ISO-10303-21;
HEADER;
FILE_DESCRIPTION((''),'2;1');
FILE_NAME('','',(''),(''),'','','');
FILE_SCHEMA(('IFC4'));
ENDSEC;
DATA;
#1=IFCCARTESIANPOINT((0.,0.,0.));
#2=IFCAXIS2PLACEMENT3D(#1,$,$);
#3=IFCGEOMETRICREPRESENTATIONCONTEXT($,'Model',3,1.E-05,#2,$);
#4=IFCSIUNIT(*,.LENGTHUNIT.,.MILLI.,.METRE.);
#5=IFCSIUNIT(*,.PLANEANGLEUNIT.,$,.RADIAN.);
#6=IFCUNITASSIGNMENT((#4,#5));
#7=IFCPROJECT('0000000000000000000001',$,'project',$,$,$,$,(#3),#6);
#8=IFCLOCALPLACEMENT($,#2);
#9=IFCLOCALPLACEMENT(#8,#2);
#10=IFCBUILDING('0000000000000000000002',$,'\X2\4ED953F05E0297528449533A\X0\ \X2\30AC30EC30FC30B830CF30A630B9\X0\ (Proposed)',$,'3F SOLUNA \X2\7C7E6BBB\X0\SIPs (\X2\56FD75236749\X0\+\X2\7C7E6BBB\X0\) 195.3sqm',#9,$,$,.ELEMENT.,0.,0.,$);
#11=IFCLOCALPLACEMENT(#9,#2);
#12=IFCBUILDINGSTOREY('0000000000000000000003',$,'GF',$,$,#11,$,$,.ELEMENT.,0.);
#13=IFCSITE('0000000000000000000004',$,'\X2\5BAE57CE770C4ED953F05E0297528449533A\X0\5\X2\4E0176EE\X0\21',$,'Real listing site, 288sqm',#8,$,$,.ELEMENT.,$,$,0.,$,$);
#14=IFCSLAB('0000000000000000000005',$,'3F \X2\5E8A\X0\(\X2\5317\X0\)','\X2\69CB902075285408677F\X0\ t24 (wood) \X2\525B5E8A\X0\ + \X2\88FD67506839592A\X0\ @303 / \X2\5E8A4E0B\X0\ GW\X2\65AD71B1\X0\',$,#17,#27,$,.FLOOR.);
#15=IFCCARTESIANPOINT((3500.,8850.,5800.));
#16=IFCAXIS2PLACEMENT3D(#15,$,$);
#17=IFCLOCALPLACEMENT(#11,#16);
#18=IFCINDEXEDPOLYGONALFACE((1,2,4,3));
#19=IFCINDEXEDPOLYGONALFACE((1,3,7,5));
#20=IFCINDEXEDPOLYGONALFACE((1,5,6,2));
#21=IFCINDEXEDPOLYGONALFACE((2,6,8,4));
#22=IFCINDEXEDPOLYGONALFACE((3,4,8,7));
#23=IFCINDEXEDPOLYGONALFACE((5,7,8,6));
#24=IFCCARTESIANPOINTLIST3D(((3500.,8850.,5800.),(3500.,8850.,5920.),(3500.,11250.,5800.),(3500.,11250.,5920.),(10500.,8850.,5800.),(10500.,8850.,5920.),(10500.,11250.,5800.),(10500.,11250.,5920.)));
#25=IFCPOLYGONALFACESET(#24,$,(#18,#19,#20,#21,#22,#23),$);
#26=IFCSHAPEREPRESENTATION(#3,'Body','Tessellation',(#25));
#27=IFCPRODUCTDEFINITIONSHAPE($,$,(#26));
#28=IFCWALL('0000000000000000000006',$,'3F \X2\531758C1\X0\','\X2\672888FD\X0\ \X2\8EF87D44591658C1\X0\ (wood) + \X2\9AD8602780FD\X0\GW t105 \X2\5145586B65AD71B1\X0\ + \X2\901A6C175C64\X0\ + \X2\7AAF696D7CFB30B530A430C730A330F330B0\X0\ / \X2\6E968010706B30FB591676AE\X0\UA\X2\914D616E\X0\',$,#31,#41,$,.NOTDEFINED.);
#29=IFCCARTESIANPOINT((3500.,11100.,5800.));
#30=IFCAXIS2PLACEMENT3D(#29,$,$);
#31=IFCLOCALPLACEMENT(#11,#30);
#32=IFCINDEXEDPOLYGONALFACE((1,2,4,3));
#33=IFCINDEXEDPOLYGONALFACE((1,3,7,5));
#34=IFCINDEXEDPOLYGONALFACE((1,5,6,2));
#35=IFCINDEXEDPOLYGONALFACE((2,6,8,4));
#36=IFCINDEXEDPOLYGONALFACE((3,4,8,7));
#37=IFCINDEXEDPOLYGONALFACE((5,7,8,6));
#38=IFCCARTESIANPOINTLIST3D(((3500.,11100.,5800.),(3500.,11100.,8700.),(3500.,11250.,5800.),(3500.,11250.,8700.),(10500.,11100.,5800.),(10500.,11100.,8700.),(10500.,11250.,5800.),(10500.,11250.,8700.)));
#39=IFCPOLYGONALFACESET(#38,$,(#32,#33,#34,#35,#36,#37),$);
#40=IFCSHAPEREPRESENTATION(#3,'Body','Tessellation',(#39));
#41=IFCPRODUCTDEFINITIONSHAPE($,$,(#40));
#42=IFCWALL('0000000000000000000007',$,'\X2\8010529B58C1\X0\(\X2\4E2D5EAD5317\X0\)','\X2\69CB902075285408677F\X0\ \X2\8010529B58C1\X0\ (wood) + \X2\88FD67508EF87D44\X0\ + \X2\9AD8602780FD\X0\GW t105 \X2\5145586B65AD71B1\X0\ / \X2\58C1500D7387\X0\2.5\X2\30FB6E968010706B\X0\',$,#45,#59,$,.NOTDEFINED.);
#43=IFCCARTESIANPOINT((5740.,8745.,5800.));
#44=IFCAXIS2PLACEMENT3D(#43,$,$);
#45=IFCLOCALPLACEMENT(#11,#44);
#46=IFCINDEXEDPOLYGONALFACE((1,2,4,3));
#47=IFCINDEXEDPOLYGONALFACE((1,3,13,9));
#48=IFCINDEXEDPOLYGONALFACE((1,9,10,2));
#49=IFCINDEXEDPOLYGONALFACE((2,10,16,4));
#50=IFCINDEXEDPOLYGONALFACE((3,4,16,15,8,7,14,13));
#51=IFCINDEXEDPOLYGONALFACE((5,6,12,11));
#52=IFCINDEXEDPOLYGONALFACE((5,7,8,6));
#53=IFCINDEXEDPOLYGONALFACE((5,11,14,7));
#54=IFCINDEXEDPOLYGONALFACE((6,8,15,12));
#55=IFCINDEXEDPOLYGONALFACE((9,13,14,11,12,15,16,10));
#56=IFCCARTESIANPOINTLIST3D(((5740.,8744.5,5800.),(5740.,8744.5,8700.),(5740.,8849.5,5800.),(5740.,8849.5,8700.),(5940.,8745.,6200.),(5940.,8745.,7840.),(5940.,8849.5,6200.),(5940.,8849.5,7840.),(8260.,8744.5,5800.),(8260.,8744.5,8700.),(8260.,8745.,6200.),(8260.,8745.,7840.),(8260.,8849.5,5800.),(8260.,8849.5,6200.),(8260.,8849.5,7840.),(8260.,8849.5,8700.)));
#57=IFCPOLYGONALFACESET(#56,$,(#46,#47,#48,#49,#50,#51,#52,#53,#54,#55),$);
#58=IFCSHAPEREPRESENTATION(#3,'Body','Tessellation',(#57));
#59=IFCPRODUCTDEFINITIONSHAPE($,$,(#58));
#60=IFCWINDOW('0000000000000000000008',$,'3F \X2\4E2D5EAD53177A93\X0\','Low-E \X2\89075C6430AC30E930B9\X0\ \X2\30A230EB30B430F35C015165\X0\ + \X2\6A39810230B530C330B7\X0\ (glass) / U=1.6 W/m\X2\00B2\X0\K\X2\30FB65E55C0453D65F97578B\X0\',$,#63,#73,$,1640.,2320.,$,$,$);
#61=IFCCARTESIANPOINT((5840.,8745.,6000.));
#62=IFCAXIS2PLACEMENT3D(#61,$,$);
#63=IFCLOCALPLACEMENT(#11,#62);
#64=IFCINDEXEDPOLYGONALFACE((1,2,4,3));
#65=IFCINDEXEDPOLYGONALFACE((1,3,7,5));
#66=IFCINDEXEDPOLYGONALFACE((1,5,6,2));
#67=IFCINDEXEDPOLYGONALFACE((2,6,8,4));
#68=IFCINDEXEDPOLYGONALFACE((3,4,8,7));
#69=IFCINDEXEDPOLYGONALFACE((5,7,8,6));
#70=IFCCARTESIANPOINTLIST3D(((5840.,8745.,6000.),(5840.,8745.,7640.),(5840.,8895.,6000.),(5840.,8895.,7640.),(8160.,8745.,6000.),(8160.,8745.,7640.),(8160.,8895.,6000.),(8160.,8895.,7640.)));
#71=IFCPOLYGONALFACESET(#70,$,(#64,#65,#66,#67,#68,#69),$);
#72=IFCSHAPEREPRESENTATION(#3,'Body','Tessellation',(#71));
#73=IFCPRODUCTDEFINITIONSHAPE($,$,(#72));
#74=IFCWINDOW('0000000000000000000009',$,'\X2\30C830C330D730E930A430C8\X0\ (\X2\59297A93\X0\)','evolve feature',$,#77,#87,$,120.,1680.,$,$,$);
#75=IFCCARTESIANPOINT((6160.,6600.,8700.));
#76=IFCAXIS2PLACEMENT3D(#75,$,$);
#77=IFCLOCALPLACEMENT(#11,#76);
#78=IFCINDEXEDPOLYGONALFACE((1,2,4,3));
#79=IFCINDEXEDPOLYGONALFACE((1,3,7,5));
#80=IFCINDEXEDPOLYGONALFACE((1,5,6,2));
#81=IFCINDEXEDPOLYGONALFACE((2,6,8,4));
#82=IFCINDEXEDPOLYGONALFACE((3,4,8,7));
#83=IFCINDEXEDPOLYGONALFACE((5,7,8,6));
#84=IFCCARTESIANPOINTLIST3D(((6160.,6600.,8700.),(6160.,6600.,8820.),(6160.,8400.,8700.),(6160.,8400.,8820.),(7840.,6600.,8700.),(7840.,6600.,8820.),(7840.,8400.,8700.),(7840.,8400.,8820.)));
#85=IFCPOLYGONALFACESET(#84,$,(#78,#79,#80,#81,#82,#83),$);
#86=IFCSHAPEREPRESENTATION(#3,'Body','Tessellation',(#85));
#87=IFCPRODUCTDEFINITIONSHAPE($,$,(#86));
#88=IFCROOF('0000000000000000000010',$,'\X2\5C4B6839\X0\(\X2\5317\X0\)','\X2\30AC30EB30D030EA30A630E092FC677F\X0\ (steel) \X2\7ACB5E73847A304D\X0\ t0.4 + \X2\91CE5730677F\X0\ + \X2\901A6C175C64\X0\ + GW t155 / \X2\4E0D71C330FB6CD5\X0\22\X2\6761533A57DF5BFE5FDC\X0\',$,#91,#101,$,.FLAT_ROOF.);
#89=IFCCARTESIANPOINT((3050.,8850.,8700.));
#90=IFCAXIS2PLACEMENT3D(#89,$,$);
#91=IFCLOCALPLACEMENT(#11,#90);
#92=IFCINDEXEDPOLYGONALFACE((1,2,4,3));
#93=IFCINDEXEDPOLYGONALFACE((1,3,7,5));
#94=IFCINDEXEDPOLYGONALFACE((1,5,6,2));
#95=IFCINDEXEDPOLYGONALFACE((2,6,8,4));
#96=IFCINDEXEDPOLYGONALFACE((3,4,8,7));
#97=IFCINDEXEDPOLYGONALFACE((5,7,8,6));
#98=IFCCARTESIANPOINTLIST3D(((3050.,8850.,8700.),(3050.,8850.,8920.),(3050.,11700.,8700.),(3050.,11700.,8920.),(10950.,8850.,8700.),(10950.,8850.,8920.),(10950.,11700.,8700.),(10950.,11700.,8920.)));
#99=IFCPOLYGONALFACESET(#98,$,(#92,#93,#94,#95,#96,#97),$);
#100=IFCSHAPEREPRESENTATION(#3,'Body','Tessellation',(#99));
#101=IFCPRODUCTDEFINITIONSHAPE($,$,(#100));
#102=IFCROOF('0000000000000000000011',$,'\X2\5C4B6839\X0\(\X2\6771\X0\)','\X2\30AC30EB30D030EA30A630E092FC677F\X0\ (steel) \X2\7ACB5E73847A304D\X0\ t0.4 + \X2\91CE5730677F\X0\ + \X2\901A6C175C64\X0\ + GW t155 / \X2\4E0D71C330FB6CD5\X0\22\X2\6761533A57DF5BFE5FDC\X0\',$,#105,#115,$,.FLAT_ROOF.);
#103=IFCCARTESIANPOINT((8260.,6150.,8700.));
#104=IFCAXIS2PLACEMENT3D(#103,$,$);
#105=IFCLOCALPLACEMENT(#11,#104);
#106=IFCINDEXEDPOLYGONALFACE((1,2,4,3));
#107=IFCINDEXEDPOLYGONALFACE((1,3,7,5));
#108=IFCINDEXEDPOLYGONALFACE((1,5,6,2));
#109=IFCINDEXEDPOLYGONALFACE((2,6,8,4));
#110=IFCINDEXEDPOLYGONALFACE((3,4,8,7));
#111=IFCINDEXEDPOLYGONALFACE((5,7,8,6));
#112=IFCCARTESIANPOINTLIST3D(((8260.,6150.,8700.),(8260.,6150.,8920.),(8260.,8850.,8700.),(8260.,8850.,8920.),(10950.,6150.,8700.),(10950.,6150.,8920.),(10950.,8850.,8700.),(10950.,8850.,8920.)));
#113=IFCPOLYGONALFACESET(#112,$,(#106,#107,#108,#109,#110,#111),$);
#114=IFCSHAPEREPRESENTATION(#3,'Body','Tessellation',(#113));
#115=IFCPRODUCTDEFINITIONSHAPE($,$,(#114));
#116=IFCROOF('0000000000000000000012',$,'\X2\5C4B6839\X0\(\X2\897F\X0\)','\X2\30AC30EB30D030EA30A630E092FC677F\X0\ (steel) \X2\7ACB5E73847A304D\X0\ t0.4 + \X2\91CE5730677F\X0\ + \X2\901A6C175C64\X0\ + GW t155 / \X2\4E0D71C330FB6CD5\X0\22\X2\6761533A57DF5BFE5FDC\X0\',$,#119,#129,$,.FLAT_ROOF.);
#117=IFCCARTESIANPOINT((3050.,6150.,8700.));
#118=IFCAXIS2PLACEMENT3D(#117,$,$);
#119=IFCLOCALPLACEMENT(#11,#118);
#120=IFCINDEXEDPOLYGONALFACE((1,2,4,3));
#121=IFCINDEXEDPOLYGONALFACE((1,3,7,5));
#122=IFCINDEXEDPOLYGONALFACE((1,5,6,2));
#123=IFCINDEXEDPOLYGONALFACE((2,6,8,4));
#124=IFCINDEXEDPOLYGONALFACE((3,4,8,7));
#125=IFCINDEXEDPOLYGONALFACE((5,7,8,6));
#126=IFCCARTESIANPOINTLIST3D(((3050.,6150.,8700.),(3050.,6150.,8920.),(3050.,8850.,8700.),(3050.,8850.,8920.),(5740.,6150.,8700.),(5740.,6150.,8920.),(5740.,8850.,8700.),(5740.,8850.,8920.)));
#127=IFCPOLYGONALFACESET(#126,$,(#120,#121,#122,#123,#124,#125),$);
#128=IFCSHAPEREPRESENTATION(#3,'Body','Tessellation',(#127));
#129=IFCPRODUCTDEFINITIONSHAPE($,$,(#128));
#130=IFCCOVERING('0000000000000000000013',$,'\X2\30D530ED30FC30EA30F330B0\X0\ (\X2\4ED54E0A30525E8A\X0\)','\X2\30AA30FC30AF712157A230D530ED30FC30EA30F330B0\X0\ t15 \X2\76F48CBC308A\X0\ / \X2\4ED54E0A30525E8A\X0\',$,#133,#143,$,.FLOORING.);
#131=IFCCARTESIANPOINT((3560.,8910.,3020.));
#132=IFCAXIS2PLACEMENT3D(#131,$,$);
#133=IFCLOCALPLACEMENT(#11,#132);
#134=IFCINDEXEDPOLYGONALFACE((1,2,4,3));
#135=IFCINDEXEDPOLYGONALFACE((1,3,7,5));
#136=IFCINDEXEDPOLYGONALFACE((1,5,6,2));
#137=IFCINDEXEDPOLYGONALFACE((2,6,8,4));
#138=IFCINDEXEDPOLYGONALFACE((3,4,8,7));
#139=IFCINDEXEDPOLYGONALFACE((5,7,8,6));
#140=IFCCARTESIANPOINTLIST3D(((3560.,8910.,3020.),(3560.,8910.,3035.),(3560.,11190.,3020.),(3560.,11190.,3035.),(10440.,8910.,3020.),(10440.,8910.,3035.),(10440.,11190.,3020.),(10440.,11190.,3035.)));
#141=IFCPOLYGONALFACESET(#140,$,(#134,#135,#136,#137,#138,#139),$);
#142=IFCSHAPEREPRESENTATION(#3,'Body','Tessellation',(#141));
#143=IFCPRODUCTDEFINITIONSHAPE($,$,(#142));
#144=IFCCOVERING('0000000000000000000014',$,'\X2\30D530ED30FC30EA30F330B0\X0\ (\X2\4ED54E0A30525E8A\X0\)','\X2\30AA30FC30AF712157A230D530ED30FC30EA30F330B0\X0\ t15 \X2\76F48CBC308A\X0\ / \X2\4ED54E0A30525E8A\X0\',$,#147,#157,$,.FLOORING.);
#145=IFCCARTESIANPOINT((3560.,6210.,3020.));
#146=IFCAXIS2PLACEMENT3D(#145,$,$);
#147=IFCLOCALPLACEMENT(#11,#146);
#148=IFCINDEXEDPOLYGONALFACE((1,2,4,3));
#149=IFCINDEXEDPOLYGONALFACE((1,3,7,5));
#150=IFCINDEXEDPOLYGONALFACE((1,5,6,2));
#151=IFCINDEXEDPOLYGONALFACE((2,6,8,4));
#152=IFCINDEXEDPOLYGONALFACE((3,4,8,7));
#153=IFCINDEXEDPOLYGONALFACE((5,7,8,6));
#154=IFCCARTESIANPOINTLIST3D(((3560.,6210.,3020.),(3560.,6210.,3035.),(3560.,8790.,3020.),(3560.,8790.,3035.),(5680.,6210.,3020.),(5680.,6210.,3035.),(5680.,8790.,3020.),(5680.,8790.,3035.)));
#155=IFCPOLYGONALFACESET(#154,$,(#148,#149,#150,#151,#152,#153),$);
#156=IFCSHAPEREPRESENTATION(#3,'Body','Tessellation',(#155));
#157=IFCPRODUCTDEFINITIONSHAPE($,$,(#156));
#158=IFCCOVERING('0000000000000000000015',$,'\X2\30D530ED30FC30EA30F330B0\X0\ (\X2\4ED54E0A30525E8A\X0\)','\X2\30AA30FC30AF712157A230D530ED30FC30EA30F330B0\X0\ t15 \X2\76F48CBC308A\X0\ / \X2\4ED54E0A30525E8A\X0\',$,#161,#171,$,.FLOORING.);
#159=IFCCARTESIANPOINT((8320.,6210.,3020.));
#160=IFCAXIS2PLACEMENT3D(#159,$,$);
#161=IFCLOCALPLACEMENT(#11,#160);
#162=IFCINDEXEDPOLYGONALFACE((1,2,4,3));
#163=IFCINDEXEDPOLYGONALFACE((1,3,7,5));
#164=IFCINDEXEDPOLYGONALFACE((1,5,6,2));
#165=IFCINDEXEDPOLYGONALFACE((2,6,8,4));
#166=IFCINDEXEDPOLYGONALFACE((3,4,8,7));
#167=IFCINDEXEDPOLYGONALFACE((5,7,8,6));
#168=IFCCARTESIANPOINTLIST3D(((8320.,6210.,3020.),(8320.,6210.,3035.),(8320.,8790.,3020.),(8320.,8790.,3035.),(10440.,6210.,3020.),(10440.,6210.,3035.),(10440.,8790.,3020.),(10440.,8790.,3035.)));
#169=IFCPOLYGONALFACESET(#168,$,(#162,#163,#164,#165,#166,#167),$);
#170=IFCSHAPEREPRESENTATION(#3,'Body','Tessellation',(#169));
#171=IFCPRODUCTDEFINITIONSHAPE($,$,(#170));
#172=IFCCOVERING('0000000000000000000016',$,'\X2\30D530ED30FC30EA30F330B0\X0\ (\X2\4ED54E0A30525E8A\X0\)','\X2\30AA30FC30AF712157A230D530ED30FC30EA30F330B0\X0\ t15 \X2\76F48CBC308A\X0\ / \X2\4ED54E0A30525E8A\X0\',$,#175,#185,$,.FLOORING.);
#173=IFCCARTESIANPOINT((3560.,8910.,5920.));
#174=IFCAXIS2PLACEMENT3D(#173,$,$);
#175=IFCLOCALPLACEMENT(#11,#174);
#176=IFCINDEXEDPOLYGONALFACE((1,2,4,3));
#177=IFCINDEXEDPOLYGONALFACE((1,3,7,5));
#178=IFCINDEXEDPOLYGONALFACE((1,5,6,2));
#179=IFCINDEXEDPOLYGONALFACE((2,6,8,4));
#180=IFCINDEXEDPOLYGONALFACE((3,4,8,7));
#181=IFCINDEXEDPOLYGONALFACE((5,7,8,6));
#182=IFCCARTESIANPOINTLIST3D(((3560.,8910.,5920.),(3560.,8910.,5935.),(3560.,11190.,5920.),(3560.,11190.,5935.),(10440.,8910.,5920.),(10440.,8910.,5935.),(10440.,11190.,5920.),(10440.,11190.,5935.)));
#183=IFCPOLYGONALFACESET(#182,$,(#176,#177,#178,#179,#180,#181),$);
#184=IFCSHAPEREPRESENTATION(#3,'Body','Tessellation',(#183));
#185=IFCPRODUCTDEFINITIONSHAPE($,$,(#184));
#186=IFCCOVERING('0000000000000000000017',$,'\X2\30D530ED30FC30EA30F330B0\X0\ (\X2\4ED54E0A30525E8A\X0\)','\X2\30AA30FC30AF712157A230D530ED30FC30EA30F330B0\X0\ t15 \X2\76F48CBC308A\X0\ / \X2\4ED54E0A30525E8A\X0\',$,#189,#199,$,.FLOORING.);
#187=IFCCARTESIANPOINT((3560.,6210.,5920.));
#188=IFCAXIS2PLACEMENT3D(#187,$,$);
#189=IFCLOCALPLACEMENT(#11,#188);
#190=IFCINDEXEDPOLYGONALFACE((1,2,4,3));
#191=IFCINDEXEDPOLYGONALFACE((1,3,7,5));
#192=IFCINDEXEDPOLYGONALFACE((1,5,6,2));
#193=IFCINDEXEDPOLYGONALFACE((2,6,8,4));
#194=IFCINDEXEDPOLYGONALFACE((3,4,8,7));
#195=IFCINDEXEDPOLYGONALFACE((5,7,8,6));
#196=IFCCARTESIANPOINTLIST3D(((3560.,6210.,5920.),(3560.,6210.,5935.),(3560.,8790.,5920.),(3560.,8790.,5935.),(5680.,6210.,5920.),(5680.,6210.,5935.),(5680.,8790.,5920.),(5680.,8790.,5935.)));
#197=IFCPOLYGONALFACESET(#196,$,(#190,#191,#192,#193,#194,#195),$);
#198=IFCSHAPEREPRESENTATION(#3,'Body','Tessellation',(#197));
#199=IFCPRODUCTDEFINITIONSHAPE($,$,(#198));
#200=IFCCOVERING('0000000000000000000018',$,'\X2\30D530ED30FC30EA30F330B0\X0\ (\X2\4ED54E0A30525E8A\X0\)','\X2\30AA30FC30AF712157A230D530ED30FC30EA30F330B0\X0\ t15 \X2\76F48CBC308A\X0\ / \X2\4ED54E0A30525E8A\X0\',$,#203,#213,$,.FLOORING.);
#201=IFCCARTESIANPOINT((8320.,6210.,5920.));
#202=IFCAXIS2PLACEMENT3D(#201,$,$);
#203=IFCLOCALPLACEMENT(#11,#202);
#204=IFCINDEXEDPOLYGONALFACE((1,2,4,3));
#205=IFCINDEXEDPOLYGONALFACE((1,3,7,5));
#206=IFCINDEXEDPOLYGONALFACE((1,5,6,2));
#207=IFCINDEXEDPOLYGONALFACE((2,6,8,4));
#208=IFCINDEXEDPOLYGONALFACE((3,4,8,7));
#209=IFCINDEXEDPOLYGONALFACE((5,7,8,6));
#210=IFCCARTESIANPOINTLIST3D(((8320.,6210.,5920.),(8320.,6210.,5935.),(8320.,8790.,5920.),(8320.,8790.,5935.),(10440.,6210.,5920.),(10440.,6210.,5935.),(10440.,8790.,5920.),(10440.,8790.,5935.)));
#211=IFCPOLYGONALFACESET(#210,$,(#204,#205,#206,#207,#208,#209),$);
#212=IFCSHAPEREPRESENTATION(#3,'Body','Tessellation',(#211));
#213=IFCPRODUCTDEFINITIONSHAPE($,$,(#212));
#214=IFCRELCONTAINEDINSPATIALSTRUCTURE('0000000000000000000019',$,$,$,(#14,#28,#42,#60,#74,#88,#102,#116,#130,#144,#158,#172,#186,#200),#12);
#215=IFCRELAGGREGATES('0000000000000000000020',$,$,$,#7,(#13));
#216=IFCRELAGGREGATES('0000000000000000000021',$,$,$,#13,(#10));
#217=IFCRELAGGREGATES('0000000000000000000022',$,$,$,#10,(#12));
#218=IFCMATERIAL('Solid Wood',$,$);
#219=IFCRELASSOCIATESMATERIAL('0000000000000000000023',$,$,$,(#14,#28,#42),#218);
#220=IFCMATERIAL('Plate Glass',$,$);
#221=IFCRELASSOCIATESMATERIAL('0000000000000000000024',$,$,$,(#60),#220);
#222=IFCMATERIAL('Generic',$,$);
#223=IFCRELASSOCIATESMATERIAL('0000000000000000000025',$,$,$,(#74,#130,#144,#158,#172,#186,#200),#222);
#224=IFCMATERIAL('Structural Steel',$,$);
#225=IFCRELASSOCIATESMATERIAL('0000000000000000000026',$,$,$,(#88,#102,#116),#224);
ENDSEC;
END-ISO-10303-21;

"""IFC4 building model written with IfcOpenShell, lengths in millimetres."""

from ifc_helpers import new_model, si_unit, frame, frame_2d, origin, place, context, project, spatial, rectangle, extrude, material, element, fill, save


model = new_model("IFC4")

# Units and contexts
model_context = context("Model", 3, precision=1e-05, world=origin())
ifc_project = project(units=[si_unit("LENGTHUNIT", "METRE", prefix="MILLI"), si_unit("PLANEANGLEUNIT", "RADIAN")], contexts=[model_context])

# Site, building, storey
site_placement = place(None, origin())
site = spatial("IfcSite", under=ifc_project, at=site_placement, Name="宮城県仙台市青葉区5丁目21", ObjectType="Real listing site, 288sqm", CompositionType="ELEMENT", RefElevation=0.0)
building_placement = place(site_placement, origin())
building = spatial("IfcBuilding", under=site, at=building_placement, Name="仙台市青葉区 ガレージハウス (Proposed)", ObjectType="3F SOLUNA 籾殻SIPs (国産杉+籾殻) 195.3sqm", CompositionType="ELEMENT", ElevationOfRefHeight=0.0, ElevationOfTerrain=0.0)
storey_placement = place(building_placement, origin())
storey = spatial("IfcBuildingStorey", under=building, at=storey_placement, Name="GF", CompositionType="ELEMENT", Elevation=0.0)

# Slab
ifc_material_1 = material(Name="Solid Wood")
slab_placement = place(storey_placement, frame((3500.0, 8850.0, 5800.0)))
element("IfcSlab", 1, at=slab_placement, inside=storey, material=ifc_material_1, Name="3F 床(北)", Description="構造用合板 t24 (wood) 剛床 + 製材根太 @303 / 床下 GW断熱", PredefinedType="FLOOR", context=model_context, shape_type="SweptSolid", body=[
    extrude(rectangle(XDim=7000.0, YDim=2400.0, at=frame_2d((3500.0, 1200.0))), frame((3500.0, 8850.0, 5800.0)), (0.0, 0.0, 1.0), 120.0),
])

# Wall
wall_1_placement = place(storey_placement, frame((3500.0, 11100.0, 5800.0)))
element("IfcWall", 2, at=wall_1_placement, inside=storey, material=ifc_material_1, Name="3F 北壁", Description="木製 軸組外壁 (wood) + 高性能GW t105 充填断熱 + 通気層 + 窯業系サイディング / 準耐火・外皮UA配慮", PredefinedType="NOTDEFINED", context=model_context, shape_type="SweptSolid", body=[
    extrude(rectangle(XDim=7000.0, YDim=150.0, at=frame_2d((3500.0, 75.0))), frame((3500.0, 11100.0, 5800.0)), (0.0, 0.0, 1.0), 2900.0),
])

# Wall, opening, window
wall_2_placement = place(storey_placement, frame((5740.0, 8745.0, 5800.0)))
wall_2 = element("IfcWall", 3, at=wall_2_placement, inside=storey, material=ifc_material_1, Name="耐力壁(中庭北)", Description="構造用合板 耐力壁 (wood) + 製材軸組 + 高性能GW t105 充填断熱 / 壁倍率2.5・準耐火", PredefinedType="NOTDEFINED", context=model_context, shape_type="SweptSolid", body=[
    extrude(rectangle(XDim=2520.0, YDim=105.0, at=frame_2d((1260.0, 52.0))), frame((5740.0, 8745.0, 5800.0)), (0.0, 0.0, 1.0), 2900.0),
])
opening_placement = place(storey_placement, frame((5840.0, 8745.0, 6000.0)))
opening = element("IfcOpeningElement", 4, at=opening_placement, cuts=wall_2, PredefinedType="NOTDEFINED", context=model_context, shape_type="SweptSolid", body=[
    extrude(rectangle(XDim=2320.0, YDim=150.0, at=frame_2d((1160.0, 75.0))), frame((5840.0, 8745.0, 6000.0)), (0.0, 0.0, 1.0), 1640.0),
])
ifc_material_2 = material(Name="Plate Glass")
window_1_placement = place(storey_placement, frame((5840.0, 8745.0, 6000.0)))
window_1 = element("IfcWindow", 5, at=window_1_placement, inside=storey, material=ifc_material_2, Name="3F 中庭北窓", Description="Low-E 複層ガラス アルゴン封入 + 樹脂サッシ (glass) / U=1.6 W/m²K・日射取得型", OverallHeight=1640.0, OverallWidth=2320.0, context=model_context, shape_type="SweptSolid", body=[
    extrude(rectangle(XDim=2320.0, YDim=150.0, at=frame_2d((1160.0, 75.0))), frame((5840.0, 8745.0, 6000.0)), (0.0, 0.0, 1.0), 1640.0),
])
fill(opening, window_1)

# Window
ifc_material_3 = material(Name="Generic")
window_2_placement = place(storey_placement, frame((6160.0, 6600.0, 8700.0)))
element("IfcWindow", 6, at=window_2_placement, inside=storey, material=ifc_material_3, Name="トップライト (天窓)", Description="evolve feature", OverallHeight=120.0, OverallWidth=1680.0, context=model_context, shape_type="SweptSolid", body=[
    extrude(rectangle(XDim=1680.0, YDim=1800.0, at=frame_2d((840.0, 900.0))), frame((6160.0, 6600.0, 8700.0)), (0.0, 0.0, 1.0), 120.0),
])

# Roofs
ifc_material_4 = material(Name="Structural Steel")
roof_1_placement = place(storey_placement, frame((3050.0, 8850.0, 8700.0)))
element("IfcRoof", 7, at=roof_1_placement, inside=storey, material=ifc_material_4, Name="屋根(北)", Description="ガルバリウム鋼板 (steel) 立平葺き t0.4 + 野地板 + 通気層 + GW t155 / 不燃・法22条区域対応", PredefinedType="FLAT_ROOF", context=model_context, shape_type="SweptSolid", body=[
    extrude(rectangle(XDim=7900.0, YDim=2850.0, at=frame_2d((3950.0, 1425.0))), frame((3050.0, 8850.0, 8700.0)), (0.0, 0.0, 1.0), 220.0),
])
roof_2_placement = place(storey_placement, frame((8260.0, 6150.0, 8700.0)))
element("IfcRoof", 8, at=roof_2_placement, inside=storey, material=ifc_material_4, Name="屋根(東)", Description="ガルバリウム鋼板 (steel) 立平葺き t0.4 + 野地板 + 通気層 + GW t155 / 不燃・法22条区域対応", PredefinedType="FLAT_ROOF", context=model_context, shape_type="SweptSolid", body=[
    extrude(rectangle(XDim=2690.0, YDim=2700.0, at=frame_2d((1345.0, 1350.0))), frame((8260.0, 6150.0, 8700.0)), (0.0, 0.0, 1.0), 220.0),
])
roof_3_placement = place(storey_placement, frame((3050.0, 6150.0, 8700.0)))
element("IfcRoof", 9, at=roof_3_placement, inside=storey, material=ifc_material_4, Name="屋根(西)", Description="ガルバリウム鋼板 (steel) 立平葺き t0.4 + 野地板 + 通気層 + GW t155 / 不燃・法22条区域対応", PredefinedType="FLAT_ROOF", context=model_context, shape_type="SweptSolid", body=[
    extrude(rectangle(XDim=2690.0, YDim=2700.0, at=frame_2d((1345.0, 1350.0))), frame((3050.0, 6150.0, 8700.0)), (0.0, 0.0, 1.0), 220.0),
])

# Coverings
covering_1_placement = place(storey_placement, frame((3560.0, 8910.0, 3020.0)))
element("IfcCovering", 10, at=covering_1_placement, inside=storey, material=ifc_material_3, Name="フローリング (仕上げ床)", Description="オーク無垢フローリング t15 直貼り / 仕上げ床", PredefinedType="FLOORING", context=model_context, shape_type="SweptSolid", body=[
    extrude(rectangle(XDim=6880.0, YDim=2280.0, at=frame_2d((3440.0, 1140.0))), frame((3560.0, 8910.0, 3020.0)), (0.0, 0.0, 1.0), 15.0),
])
covering_2_placement = place(storey_placement, frame((3560.0, 6210.0, 3020.0)))
element("IfcCovering", 11, at=covering_2_placement, inside=storey, material=ifc_material_3, Name="フローリング (仕上げ床)", Description="オーク無垢フローリング t15 直貼り / 仕上げ床", PredefinedType="FLOORING", context=model_context, shape_type="SweptSolid", body=[
    extrude(rectangle(XDim=2120.0, YDim=2580.0, at=frame_2d((1060.0, 1290.0))), frame((3560.0, 6210.0, 3020.0)), (0.0, 0.0, 1.0), 15.0),
])
covering_3_placement = place(storey_placement, frame((8320.0, 6210.0, 3020.0)))
element("IfcCovering", 12, at=covering_3_placement, inside=storey, material=ifc_material_3, Name="フローリング (仕上げ床)", Description="オーク無垢フローリング t15 直貼り / 仕上げ床", PredefinedType="FLOORING", context=model_context, shape_type="SweptSolid", body=[
    extrude(rectangle(XDim=2120.0, YDim=2580.0, at=frame_2d((1060.0, 1290.0))), frame((8320.0, 6210.0, 3020.0)), (0.0, 0.0, 1.0), 15.0),
])
covering_4_placement = place(storey_placement, frame((3560.0, 8910.0, 5920.0)))
element("IfcCovering", 13, at=covering_4_placement, inside=storey, material=ifc_material_3, Name="フローリング (仕上げ床)", Description="オーク無垢フローリング t15 直貼り / 仕上げ床", PredefinedType="FLOORING", context=model_context, shape_type="SweptSolid", body=[
    extrude(rectangle(XDim=6880.0, YDim=2280.0, at=frame_2d((3440.0, 1140.0))), frame((3560.0, 8910.0, 5920.0)), (0.0, 0.0, 1.0), 15.0),
])
covering_5_placement = place(storey_placement, frame((3560.0, 6210.0, 5920.0)))
element("IfcCovering", 14, at=covering_5_placement, inside=storey, material=ifc_material_3, Name="フローリング (仕上げ床)", Description="オーク無垢フローリング t15 直貼り / 仕上げ床", PredefinedType="FLOORING", context=model_context, shape_type="SweptSolid", body=[
    extrude(rectangle(XDim=2120.0, YDim=2580.0, at=frame_2d((1060.0, 1290.0))), frame((3560.0, 6210.0, 5920.0)), (0.0, 0.0, 1.0), 15.0),
])
covering_6_placement = place(storey_placement, frame((8320.0, 6210.0, 5920.0)))
element("IfcCovering", 15, at=covering_6_placement, inside=storey, material=ifc_material_3, Name="フローリング (仕上げ床)", Description="オーク無垢フローリング t15 直貼り / 仕上げ床", PredefinedType="FLOORING", context=model_context, shape_type="SweptSolid", body=[
    extrude(rectangle(XDim=2120.0, YDim=2580.0, at=frame_2d((1060.0, 1290.0))), frame((8320.0, 6210.0, 5920.0)), (0.0, 0.0, 1.0), 15.0),
])

save(model, "model.ifc")
